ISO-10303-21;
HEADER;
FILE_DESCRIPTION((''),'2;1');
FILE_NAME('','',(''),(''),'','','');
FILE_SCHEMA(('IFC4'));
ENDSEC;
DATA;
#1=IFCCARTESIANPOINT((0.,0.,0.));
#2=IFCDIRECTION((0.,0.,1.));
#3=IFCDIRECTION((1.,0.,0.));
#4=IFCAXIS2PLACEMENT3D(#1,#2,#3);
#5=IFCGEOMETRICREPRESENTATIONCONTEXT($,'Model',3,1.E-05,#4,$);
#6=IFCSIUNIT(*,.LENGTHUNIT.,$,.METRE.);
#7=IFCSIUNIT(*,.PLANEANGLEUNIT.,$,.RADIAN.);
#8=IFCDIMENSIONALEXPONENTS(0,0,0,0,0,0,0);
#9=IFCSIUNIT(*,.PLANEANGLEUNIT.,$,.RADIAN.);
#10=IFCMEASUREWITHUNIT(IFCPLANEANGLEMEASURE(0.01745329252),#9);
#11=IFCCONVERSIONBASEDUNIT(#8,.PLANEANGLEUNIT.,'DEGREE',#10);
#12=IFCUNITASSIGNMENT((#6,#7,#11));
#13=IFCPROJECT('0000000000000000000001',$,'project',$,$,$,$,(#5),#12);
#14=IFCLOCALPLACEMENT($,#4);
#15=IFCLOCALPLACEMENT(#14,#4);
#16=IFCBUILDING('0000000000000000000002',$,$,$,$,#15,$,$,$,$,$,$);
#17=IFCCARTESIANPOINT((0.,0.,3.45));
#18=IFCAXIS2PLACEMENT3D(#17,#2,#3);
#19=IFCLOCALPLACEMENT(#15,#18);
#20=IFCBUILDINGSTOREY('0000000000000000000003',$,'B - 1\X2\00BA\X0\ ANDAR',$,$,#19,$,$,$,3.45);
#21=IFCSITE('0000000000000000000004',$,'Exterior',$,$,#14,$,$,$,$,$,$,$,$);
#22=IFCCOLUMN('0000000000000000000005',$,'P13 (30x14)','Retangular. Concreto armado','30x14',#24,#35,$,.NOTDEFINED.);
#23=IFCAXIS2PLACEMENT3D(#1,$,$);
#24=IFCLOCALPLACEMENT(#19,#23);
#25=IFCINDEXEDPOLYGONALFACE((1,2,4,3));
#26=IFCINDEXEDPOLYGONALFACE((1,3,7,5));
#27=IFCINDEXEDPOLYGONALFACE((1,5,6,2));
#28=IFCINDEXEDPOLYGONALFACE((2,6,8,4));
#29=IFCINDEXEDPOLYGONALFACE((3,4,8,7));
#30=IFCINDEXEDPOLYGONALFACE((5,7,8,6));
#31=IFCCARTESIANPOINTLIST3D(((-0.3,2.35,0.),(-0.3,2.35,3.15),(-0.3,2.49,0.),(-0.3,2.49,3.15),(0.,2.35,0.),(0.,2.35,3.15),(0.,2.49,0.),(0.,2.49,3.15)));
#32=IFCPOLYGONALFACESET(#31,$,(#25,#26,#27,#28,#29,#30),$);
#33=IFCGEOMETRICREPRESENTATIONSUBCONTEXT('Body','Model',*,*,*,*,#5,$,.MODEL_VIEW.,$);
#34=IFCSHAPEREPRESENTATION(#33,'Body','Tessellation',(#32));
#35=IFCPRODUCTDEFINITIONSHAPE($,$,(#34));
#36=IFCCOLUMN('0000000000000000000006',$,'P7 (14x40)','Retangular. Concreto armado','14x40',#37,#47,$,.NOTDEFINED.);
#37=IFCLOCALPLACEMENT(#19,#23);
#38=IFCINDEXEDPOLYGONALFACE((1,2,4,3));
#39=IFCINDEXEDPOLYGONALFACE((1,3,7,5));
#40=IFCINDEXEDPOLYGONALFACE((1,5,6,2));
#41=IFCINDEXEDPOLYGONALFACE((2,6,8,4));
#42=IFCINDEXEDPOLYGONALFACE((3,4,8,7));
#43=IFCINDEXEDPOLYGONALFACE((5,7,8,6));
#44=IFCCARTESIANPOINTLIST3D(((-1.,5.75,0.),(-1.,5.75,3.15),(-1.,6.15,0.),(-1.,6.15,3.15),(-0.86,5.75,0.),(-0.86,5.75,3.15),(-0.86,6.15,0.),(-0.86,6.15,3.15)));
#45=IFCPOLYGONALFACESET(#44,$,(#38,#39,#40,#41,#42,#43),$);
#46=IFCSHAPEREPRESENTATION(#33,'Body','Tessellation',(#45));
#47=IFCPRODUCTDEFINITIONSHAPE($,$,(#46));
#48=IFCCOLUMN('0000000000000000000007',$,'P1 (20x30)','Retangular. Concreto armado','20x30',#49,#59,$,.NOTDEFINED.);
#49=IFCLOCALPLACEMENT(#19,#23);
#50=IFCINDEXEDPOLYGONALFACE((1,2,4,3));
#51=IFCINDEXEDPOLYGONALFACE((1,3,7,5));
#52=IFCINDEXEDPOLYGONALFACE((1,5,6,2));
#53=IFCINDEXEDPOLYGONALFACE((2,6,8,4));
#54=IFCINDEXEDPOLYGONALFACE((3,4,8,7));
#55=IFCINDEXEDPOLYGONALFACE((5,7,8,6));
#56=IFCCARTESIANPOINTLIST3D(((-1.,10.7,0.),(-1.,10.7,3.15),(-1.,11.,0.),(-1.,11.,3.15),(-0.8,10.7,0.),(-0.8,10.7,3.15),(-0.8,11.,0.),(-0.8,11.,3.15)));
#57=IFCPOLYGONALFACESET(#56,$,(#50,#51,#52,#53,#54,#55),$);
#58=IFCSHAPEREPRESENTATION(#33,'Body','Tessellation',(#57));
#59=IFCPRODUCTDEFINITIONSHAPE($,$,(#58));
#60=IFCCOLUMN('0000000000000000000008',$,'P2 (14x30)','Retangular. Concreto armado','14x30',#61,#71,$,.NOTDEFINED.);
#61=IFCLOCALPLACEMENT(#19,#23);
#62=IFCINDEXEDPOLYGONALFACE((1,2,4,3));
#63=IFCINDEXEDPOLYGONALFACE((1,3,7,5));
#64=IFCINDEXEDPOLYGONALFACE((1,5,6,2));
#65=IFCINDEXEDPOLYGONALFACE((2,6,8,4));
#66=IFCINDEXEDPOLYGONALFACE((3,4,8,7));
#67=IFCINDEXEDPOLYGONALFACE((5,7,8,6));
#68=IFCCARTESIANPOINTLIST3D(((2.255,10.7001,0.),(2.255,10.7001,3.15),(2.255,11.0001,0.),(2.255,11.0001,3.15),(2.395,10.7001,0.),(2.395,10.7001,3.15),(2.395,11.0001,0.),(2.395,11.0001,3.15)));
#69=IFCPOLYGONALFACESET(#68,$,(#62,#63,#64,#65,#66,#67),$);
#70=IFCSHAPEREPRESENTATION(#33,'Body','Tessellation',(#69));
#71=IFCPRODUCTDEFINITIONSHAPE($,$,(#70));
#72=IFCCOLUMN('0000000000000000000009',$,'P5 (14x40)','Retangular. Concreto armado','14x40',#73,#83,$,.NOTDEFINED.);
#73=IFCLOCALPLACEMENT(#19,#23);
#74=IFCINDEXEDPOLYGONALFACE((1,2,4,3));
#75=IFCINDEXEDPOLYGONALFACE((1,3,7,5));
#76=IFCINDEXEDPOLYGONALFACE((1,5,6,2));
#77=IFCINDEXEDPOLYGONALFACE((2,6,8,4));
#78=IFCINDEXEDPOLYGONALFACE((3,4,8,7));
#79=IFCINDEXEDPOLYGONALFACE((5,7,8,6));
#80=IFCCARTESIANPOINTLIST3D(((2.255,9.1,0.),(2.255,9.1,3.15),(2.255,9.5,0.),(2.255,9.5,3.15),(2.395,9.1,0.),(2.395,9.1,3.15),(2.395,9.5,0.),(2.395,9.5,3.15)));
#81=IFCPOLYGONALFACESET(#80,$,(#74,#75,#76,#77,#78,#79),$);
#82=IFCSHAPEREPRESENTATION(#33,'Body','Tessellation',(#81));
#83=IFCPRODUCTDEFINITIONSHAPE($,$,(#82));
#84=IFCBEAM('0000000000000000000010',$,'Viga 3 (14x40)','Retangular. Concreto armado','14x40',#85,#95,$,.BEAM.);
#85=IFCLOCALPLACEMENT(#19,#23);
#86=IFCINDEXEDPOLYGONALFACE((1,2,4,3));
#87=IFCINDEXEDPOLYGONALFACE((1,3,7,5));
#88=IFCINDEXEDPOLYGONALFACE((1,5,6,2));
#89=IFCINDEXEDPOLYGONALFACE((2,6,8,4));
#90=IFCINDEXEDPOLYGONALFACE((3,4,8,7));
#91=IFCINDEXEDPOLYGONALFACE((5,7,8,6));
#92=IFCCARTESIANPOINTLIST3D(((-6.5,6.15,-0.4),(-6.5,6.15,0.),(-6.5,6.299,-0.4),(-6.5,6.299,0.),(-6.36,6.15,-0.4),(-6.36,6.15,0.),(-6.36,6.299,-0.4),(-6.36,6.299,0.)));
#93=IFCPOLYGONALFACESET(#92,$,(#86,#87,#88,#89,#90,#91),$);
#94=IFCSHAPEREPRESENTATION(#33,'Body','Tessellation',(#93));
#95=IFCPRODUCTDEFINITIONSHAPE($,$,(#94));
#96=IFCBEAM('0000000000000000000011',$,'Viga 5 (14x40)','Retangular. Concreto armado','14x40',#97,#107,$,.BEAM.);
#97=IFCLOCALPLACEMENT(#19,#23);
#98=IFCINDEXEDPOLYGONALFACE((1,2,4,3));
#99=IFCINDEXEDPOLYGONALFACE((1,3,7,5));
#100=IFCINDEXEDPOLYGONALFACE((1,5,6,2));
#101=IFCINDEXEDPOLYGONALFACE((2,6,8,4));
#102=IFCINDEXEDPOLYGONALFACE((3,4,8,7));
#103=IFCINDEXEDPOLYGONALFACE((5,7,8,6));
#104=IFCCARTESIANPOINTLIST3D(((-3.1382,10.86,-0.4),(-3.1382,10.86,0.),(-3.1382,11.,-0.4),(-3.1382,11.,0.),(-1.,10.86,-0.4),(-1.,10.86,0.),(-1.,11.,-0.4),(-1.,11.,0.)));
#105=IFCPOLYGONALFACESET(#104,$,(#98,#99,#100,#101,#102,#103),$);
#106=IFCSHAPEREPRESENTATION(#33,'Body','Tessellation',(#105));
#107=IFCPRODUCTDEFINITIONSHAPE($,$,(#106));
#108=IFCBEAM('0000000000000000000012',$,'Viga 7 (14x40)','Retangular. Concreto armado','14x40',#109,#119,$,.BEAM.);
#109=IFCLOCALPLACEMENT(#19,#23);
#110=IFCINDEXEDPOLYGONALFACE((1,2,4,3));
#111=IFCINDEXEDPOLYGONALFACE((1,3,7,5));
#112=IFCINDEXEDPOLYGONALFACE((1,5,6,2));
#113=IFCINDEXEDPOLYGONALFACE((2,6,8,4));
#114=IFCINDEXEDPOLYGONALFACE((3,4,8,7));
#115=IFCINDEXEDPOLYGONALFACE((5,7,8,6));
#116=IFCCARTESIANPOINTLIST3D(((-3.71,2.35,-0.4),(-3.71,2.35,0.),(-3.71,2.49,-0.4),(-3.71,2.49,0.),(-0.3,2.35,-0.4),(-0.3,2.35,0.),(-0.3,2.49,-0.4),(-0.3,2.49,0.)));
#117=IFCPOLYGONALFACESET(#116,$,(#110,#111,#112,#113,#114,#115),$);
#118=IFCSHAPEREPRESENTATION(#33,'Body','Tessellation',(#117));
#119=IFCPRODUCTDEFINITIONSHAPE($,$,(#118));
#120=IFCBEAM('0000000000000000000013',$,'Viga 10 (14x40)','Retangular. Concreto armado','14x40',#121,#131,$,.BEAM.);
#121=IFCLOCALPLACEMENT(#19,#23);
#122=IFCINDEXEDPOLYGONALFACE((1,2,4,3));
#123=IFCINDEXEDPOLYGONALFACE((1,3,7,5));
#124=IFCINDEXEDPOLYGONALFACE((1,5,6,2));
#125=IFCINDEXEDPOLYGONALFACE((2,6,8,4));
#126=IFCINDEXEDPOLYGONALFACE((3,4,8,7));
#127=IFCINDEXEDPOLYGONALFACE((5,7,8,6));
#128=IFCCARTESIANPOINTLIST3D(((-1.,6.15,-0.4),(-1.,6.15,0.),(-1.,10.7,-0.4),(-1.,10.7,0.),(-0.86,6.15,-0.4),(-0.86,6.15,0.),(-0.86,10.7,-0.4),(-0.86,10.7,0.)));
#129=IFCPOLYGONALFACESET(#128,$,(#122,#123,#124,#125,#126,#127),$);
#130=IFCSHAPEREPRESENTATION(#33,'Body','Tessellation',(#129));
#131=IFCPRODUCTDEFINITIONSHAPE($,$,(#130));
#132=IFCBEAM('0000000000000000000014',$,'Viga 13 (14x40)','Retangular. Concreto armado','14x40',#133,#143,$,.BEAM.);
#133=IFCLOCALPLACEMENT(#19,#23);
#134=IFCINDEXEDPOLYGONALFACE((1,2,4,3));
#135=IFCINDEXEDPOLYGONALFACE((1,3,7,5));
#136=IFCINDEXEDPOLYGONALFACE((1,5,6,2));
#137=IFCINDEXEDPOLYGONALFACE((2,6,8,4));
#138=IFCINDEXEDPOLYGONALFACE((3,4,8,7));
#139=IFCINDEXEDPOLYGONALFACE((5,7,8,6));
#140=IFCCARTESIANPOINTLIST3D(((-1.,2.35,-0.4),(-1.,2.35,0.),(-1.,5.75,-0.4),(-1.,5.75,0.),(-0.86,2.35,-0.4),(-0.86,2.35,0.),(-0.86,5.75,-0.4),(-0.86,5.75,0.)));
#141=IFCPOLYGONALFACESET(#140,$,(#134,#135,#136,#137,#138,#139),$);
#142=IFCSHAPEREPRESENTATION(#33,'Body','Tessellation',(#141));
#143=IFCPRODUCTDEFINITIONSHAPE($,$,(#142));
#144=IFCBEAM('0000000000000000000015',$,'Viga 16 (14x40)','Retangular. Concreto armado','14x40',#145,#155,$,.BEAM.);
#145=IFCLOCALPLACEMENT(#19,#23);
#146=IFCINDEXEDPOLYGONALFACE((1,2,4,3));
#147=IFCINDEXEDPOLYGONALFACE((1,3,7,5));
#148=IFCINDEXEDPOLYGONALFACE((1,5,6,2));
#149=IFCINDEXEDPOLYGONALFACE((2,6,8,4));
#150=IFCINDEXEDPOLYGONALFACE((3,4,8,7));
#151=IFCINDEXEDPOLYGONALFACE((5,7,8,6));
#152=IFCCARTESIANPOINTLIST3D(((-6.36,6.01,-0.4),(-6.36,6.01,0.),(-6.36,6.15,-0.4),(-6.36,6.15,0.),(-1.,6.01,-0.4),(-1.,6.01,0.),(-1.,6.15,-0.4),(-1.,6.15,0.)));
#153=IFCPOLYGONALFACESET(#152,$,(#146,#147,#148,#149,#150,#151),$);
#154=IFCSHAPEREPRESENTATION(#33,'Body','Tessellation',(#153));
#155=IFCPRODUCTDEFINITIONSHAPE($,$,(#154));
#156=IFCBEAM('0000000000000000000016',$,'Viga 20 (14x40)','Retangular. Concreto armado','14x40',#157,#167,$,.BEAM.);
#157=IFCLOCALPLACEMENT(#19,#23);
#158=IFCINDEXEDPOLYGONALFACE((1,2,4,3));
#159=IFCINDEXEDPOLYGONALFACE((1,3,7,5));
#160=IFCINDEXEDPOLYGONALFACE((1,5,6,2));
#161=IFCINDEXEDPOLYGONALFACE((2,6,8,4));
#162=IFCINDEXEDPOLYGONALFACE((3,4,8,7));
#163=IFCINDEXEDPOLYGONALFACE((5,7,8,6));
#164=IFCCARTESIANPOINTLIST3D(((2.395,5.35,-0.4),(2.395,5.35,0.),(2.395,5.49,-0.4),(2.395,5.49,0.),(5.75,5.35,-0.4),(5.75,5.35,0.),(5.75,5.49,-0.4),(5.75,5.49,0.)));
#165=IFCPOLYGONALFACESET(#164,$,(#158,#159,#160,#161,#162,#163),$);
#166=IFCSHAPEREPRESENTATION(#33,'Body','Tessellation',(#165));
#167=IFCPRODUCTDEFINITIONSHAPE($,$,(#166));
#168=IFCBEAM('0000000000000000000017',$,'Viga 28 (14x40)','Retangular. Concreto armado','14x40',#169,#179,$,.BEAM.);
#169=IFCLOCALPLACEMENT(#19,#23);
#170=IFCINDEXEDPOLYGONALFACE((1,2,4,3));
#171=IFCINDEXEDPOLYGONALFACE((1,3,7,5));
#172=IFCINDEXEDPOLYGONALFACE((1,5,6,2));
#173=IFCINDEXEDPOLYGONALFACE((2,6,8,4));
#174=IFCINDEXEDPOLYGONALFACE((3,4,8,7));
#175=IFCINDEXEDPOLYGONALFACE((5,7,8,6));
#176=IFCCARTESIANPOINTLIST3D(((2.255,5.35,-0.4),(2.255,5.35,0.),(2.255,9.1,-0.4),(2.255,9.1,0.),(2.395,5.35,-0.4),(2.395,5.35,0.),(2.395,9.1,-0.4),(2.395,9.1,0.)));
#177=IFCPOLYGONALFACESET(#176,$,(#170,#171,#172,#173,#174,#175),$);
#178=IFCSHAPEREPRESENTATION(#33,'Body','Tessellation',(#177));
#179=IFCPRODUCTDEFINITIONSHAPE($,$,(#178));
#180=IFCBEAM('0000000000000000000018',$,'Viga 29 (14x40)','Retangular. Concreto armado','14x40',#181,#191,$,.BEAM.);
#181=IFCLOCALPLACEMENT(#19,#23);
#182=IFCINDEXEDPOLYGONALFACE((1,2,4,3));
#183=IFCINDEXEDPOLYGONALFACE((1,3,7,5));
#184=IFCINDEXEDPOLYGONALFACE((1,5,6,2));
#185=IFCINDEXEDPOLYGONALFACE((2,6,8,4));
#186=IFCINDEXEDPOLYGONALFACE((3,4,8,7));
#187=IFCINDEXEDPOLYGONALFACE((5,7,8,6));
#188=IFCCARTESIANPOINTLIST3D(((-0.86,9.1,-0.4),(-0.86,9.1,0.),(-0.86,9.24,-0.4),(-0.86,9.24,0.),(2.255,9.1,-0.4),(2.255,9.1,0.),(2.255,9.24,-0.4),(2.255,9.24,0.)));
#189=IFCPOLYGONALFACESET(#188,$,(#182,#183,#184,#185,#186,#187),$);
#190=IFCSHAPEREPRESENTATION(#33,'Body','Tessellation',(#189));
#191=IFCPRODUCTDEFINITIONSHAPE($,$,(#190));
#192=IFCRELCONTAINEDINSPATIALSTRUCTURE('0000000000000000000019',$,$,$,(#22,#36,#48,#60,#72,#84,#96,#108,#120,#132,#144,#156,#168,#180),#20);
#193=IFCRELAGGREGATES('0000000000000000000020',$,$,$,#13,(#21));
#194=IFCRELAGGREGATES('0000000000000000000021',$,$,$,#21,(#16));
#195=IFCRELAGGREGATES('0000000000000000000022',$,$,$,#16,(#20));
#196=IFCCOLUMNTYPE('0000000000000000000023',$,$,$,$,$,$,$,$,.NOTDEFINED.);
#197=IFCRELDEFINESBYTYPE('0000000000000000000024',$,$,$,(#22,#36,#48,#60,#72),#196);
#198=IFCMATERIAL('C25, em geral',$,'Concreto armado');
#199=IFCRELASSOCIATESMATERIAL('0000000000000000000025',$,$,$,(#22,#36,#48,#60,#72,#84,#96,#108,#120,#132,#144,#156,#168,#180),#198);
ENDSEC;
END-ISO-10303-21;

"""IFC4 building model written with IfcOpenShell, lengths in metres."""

from ifc_helpers import new_model, entity, si_unit, converted_unit, frame, frame_2d, origin_with_axes, origin_2d_with_axis, place, context, subcontext, project, spatial, rectangle, extrude, material, type_object, element, save


model = new_model("IFC4")

# Units and contexts
model_context = context("Model", 3, precision=1e-05, world=origin_with_axes())
body_context = subcontext(model_context, "Body", "Model", "MODEL_VIEW")
ifc_project = project(units=[si_unit("LENGTHUNIT", "METRE"), si_unit("PLANEANGLEUNIT", "RADIAN"), converted_unit("PLANEANGLEUNIT", "DEGREE", entity("IfcPlaneAngleMeasure", 0.01745329252), si_unit("PLANEANGLEUNIT", "RADIAN"), dimensions=[0, 0, 0, 0, 0, 0, 0])], contexts=[model_context])

# Site, building, storey
site_placement = place(None, origin_with_axes())
site = spatial("IfcSite", under=ifc_project, at=site_placement, Name="Exterior")
building_placement = place(site_placement, origin_with_axes())
building = spatial("IfcBuilding", under=site, at=building_placement)
storey_placement = place(building_placement, frame((0.0, 0.0, 3.45), z_axis=(0.0, 0.0, 1.0), x_axis=(1.0, 0.0, 0.0)))
storey = spatial("IfcBuildingStorey", under=building, at=storey_placement, Name="B - 1º ANDAR", Elevation=3.45)

# Columns
ifc_material = material(Name="C25, em geral", Category="Concreto armado")
column_type = type_object("IfcColumnType", PredefinedType="NOTDEFINED")
column_1_placement = place(storey_placement, frame((-0.15, 2.42, 0.0), z_axis=(0.0, 0.0, 1.0), x_axis=(1.0, 0.0, 0.0)))
element("IfcColumn", 1, at=column_1_placement, inside=storey, type_object=column_type, material=ifc_material, Name="P13 (30x14)", Description="Retangular. Concreto armado", ObjectType="30x14", PredefinedType="NOTDEFINED", context=body_context, shape_type="SweptSolid", body=[
    extrude(rectangle(XDim=0.3, YDim=0.14, at=origin_2d_with_axis()), origin_with_axes(), (0.0, 0.0, 1.0), 3.15),
])
column_2_placement = place(storey_placement, frame((-0.93, 6.15, 0.0), z_axis=(0.0, 0.0, 1.0), x_axis=(1.0, 0.0, 0.0)))
element("IfcColumn", 2, at=column_2_placement, inside=storey, type_object=column_type, material=ifc_material, Name="P7 (14x40)", Description="Retangular. Concreto armado", ObjectType="14x40", PredefinedType="NOTDEFINED", context=body_context, shape_type="SweptSolid", body=[
    extrude(rectangle(XDim=0.14, YDim=0.4, at=frame_2d((0.0, -0.2), x_axis=(1.0, 0.0))), origin_with_axes(), (0.0, 0.0, 1.0), 3.15),
])
column_3_placement = place(storey_placement, frame((-1.0, 11.0, 0.0), z_axis=(0.0, 0.0, 1.0), x_axis=(1.0, 0.0, 0.0)))
element("IfcColumn", 3, at=column_3_placement, inside=storey, type_object=column_type, material=ifc_material, Name="P1 (20x30)", Description="Retangular. Concreto armado", ObjectType="20x30", PredefinedType="NOTDEFINED", context=body_context, shape_type="SweptSolid", body=[
    extrude(rectangle(XDim=0.2, YDim=0.3, at=frame_2d((0.1, -0.15), x_axis=(1.0, 0.0))), origin_with_axes(), (0.0, 0.0, 1.0), 3.15),
])
column_4_placement = place(storey_placement, frame((2.325, 10.8501, 0.0), z_axis=(0.0, 0.0, 1.0), x_axis=(1.0, 0.0, 0.0)))
element("IfcColumn", 4, at=column_4_placement, inside=storey, type_object=column_type, material=ifc_material, Name="P2 (14x30)", Description="Retangular. Concreto armado", ObjectType="14x30", PredefinedType="NOTDEFINED", context=body_context, shape_type="SweptSolid", body=[
    extrude(rectangle(XDim=0.14, YDim=0.3, at=origin_2d_with_axis()), origin_with_axes(), (0.0, 0.0, 1.0), 3.15),
])
column_5_placement = place(storey_placement, frame((2.325, 9.1, 0.0), z_axis=(0.0, 0.0, 1.0), x_axis=(1.0, 0.0, 0.0)))
element("IfcColumn", 5, at=column_5_placement, inside=storey, type_object=column_type, material=ifc_material, Name="P5 (14x40)", Description="Retangular. Concreto armado", ObjectType="14x40", PredefinedType="NOTDEFINED", context=body_context, shape_type="SweptSolid", body=[
    extrude(rectangle(XDim=0.14, YDim=0.4, at=frame_2d((0.0, 0.2), x_axis=(1.0, 0.0))), origin_with_axes(), (0.0, 0.0, 1.0), 3.15),
])

# Beams
beam_1_placement = place(storey_placement, frame((-6.43, 6.15, 0.0), z_axis=(0.0, 1.0, 0.0), x_axis=(-1.0, 0.0, 0.0)))
element("IfcBeam", 6, at=beam_1_placement, inside=storey, material=ifc_material, Name="Viga 3 (14x40)", Description="Retangular. Concreto armado", ObjectType="14x40", PredefinedType="BEAM", context=body_context, shape_type="SweptSolid", body=[
    extrude(rectangle(XDim=0.14, YDim=0.4, at=frame_2d((0.0, -0.2), x_axis=(1.0, 0.0))), origin_with_axes(), (0.0, 0.0, 1.0), 0.149),
])
beam_2_placement = place(storey_placement, frame((-3.1382, 10.93, 0.0), z_axis=(1.0, 0.0, 0.0), x_axis=(0.0, 1.0, 0.0)))
element("IfcBeam", 7, at=beam_2_placement, inside=storey, material=ifc_material, Name="Viga 5 (14x40)", Description="Retangular. Concreto armado", ObjectType="14x40", PredefinedType="BEAM", context=body_context, shape_type="SweptSolid", body=[
    extrude(rectangle(XDim=0.14, YDim=0.4, at=frame_2d((0.0, -0.2), x_axis=(1.0, 0.0))), origin_with_axes(), (0.0, 0.0, 1.0), 2.1382),
])
beam_3_placement = place(storey_placement, frame((-0.3, 2.42, 0.0), z_axis=(-1.0, 0.0, 0.0), x_axis=(0.0, -1.0, 0.0)))
element("IfcBeam", 8, at=beam_3_placement, inside=storey, material=ifc_material, Name="Viga 7 (14x40)", Description="Retangular. Concreto armado", ObjectType="14x40", PredefinedType="BEAM", context=body_context, shape_type="SweptSolid", body=[
    extrude(rectangle(XDim=0.14, YDim=0.4, at=frame_2d((0.0, -0.2), x_axis=(1.0, 0.0))), origin_with_axes(), (0.0, 0.0, 1.0), 3.41),
])
beam_4_placement = place(storey_placement, frame((-0.93, 10.7, 0.0), z_axis=(0.0, -1.0, 0.0), x_axis=(1.0, 0.0, 0.0)))
element("IfcBeam", 9, at=beam_4_placement, inside=storey, material=ifc_material, Name="Viga 10 (14x40)", Description="Retangular. Concreto armado", ObjectType="14x40", PredefinedType="BEAM", context=body_context, shape_type="SweptSolid", body=[
    extrude(rectangle(XDim=0.14, YDim=0.4, at=frame_2d((0.0, -0.2), x_axis=(1.0, 0.0))), origin_with_axes(), (0.0, 0.0, 1.0), 4.55),
])
beam_5_placement = place(storey_placement, frame((-0.93, 2.35, 0.0), z_axis=(0.0, 1.0, 0.0), x_axis=(-1.0, 0.0, 0.0)))
element("IfcBeam", 10, at=beam_5_placement, inside=storey, material=ifc_material, Name="Viga 13 (14x40)", Description="Retangular. Concreto armado", ObjectType="14x40", PredefinedType="BEAM", context=body_context, shape_type="SweptSolid", body=[
    extrude(rectangle(XDim=0.14, YDim=0.4, at=frame_2d((0.0, -0.2), x_axis=(1.0, 0.0))), origin_with_axes(), (0.0, 0.0, 1.0), 3.4),
])
beam_6_placement = place(storey_placement, frame((-6.36, 6.08, 0.0), z_axis=(1.0, 0.0, 0.0), x_axis=(0.0, 1.0, 0.0)))
element("IfcBeam", 11, at=beam_6_placement, inside=storey, material=ifc_material, Name="Viga 16 (14x40)", Description="Retangular. Concreto armado", ObjectType="14x40", PredefinedType="BEAM", context=body_context, shape_type="SweptSolid", body=[
    extrude(rectangle(XDim=0.14, YDim=0.4, at=frame_2d((0.0, -0.2), x_axis=(1.0, 0.0))), origin_with_axes(), (0.0, 0.0, 1.0), 5.36),
])
beam_7_placement = place(storey_placement, frame((2.395, 5.42, 0.0), z_axis=(1.0, 0.0, 0.0), x_axis=(0.0, 1.0, 0.0)))
element("IfcBeam", 12, at=beam_7_placement, inside=storey, material=ifc_material, Name="Viga 20 (14x40)", Description="Retangular. Concreto armado", ObjectType="14x40", PredefinedType="BEAM", context=body_context, shape_type="SweptSolid", body=[
    extrude(rectangle(XDim=0.14, YDim=0.4, at=frame_2d((0.0, -0.2), x_axis=(1.0, 0.0))), origin_with_axes(), (0.0, 0.0, 1.0), 3.355),
])
beam_8_placement = place(storey_placement, frame((2.325, 9.1, 0.0), z_axis=(0.0, -1.0, 0.0), x_axis=(1.0, 0.0, 0.0)))
element("IfcBeam", 13, at=beam_8_placement, inside=storey, material=ifc_material, Name="Viga 28 (14x40)", Description="Retangular. Concreto armado", ObjectType="14x40", PredefinedType="BEAM", context=body_context, shape_type="SweptSolid", body=[
    extrude(rectangle(XDim=0.14, YDim=0.4, at=frame_2d((0.0, -0.2), x_axis=(1.0, 0.0))), origin_with_axes(), (0.0, 0.0, 1.0), 3.75),
])
beam_9_placement = place(storey_placement, frame((2.255, 9.17, 0.0), z_axis=(-1.0, 0.0, 0.0), x_axis=(0.0, -1.0, 0.0)))
element("IfcBeam", 14, at=beam_9_placement, inside=storey, material=ifc_material, Name="Viga 29 (14x40)", Description="Retangular. Concreto armado", ObjectType="14x40", PredefinedType="BEAM", context=body_context, shape_type="SweptSolid", body=[
    extrude(rectangle(XDim=0.14, YDim=0.4, at=frame_2d((0.0, -0.2), x_axis=(1.0, 0.0))), origin_with_axes(), (0.0, 0.0, 1.0), 3.115),
])

save(model, "model.ifc")
